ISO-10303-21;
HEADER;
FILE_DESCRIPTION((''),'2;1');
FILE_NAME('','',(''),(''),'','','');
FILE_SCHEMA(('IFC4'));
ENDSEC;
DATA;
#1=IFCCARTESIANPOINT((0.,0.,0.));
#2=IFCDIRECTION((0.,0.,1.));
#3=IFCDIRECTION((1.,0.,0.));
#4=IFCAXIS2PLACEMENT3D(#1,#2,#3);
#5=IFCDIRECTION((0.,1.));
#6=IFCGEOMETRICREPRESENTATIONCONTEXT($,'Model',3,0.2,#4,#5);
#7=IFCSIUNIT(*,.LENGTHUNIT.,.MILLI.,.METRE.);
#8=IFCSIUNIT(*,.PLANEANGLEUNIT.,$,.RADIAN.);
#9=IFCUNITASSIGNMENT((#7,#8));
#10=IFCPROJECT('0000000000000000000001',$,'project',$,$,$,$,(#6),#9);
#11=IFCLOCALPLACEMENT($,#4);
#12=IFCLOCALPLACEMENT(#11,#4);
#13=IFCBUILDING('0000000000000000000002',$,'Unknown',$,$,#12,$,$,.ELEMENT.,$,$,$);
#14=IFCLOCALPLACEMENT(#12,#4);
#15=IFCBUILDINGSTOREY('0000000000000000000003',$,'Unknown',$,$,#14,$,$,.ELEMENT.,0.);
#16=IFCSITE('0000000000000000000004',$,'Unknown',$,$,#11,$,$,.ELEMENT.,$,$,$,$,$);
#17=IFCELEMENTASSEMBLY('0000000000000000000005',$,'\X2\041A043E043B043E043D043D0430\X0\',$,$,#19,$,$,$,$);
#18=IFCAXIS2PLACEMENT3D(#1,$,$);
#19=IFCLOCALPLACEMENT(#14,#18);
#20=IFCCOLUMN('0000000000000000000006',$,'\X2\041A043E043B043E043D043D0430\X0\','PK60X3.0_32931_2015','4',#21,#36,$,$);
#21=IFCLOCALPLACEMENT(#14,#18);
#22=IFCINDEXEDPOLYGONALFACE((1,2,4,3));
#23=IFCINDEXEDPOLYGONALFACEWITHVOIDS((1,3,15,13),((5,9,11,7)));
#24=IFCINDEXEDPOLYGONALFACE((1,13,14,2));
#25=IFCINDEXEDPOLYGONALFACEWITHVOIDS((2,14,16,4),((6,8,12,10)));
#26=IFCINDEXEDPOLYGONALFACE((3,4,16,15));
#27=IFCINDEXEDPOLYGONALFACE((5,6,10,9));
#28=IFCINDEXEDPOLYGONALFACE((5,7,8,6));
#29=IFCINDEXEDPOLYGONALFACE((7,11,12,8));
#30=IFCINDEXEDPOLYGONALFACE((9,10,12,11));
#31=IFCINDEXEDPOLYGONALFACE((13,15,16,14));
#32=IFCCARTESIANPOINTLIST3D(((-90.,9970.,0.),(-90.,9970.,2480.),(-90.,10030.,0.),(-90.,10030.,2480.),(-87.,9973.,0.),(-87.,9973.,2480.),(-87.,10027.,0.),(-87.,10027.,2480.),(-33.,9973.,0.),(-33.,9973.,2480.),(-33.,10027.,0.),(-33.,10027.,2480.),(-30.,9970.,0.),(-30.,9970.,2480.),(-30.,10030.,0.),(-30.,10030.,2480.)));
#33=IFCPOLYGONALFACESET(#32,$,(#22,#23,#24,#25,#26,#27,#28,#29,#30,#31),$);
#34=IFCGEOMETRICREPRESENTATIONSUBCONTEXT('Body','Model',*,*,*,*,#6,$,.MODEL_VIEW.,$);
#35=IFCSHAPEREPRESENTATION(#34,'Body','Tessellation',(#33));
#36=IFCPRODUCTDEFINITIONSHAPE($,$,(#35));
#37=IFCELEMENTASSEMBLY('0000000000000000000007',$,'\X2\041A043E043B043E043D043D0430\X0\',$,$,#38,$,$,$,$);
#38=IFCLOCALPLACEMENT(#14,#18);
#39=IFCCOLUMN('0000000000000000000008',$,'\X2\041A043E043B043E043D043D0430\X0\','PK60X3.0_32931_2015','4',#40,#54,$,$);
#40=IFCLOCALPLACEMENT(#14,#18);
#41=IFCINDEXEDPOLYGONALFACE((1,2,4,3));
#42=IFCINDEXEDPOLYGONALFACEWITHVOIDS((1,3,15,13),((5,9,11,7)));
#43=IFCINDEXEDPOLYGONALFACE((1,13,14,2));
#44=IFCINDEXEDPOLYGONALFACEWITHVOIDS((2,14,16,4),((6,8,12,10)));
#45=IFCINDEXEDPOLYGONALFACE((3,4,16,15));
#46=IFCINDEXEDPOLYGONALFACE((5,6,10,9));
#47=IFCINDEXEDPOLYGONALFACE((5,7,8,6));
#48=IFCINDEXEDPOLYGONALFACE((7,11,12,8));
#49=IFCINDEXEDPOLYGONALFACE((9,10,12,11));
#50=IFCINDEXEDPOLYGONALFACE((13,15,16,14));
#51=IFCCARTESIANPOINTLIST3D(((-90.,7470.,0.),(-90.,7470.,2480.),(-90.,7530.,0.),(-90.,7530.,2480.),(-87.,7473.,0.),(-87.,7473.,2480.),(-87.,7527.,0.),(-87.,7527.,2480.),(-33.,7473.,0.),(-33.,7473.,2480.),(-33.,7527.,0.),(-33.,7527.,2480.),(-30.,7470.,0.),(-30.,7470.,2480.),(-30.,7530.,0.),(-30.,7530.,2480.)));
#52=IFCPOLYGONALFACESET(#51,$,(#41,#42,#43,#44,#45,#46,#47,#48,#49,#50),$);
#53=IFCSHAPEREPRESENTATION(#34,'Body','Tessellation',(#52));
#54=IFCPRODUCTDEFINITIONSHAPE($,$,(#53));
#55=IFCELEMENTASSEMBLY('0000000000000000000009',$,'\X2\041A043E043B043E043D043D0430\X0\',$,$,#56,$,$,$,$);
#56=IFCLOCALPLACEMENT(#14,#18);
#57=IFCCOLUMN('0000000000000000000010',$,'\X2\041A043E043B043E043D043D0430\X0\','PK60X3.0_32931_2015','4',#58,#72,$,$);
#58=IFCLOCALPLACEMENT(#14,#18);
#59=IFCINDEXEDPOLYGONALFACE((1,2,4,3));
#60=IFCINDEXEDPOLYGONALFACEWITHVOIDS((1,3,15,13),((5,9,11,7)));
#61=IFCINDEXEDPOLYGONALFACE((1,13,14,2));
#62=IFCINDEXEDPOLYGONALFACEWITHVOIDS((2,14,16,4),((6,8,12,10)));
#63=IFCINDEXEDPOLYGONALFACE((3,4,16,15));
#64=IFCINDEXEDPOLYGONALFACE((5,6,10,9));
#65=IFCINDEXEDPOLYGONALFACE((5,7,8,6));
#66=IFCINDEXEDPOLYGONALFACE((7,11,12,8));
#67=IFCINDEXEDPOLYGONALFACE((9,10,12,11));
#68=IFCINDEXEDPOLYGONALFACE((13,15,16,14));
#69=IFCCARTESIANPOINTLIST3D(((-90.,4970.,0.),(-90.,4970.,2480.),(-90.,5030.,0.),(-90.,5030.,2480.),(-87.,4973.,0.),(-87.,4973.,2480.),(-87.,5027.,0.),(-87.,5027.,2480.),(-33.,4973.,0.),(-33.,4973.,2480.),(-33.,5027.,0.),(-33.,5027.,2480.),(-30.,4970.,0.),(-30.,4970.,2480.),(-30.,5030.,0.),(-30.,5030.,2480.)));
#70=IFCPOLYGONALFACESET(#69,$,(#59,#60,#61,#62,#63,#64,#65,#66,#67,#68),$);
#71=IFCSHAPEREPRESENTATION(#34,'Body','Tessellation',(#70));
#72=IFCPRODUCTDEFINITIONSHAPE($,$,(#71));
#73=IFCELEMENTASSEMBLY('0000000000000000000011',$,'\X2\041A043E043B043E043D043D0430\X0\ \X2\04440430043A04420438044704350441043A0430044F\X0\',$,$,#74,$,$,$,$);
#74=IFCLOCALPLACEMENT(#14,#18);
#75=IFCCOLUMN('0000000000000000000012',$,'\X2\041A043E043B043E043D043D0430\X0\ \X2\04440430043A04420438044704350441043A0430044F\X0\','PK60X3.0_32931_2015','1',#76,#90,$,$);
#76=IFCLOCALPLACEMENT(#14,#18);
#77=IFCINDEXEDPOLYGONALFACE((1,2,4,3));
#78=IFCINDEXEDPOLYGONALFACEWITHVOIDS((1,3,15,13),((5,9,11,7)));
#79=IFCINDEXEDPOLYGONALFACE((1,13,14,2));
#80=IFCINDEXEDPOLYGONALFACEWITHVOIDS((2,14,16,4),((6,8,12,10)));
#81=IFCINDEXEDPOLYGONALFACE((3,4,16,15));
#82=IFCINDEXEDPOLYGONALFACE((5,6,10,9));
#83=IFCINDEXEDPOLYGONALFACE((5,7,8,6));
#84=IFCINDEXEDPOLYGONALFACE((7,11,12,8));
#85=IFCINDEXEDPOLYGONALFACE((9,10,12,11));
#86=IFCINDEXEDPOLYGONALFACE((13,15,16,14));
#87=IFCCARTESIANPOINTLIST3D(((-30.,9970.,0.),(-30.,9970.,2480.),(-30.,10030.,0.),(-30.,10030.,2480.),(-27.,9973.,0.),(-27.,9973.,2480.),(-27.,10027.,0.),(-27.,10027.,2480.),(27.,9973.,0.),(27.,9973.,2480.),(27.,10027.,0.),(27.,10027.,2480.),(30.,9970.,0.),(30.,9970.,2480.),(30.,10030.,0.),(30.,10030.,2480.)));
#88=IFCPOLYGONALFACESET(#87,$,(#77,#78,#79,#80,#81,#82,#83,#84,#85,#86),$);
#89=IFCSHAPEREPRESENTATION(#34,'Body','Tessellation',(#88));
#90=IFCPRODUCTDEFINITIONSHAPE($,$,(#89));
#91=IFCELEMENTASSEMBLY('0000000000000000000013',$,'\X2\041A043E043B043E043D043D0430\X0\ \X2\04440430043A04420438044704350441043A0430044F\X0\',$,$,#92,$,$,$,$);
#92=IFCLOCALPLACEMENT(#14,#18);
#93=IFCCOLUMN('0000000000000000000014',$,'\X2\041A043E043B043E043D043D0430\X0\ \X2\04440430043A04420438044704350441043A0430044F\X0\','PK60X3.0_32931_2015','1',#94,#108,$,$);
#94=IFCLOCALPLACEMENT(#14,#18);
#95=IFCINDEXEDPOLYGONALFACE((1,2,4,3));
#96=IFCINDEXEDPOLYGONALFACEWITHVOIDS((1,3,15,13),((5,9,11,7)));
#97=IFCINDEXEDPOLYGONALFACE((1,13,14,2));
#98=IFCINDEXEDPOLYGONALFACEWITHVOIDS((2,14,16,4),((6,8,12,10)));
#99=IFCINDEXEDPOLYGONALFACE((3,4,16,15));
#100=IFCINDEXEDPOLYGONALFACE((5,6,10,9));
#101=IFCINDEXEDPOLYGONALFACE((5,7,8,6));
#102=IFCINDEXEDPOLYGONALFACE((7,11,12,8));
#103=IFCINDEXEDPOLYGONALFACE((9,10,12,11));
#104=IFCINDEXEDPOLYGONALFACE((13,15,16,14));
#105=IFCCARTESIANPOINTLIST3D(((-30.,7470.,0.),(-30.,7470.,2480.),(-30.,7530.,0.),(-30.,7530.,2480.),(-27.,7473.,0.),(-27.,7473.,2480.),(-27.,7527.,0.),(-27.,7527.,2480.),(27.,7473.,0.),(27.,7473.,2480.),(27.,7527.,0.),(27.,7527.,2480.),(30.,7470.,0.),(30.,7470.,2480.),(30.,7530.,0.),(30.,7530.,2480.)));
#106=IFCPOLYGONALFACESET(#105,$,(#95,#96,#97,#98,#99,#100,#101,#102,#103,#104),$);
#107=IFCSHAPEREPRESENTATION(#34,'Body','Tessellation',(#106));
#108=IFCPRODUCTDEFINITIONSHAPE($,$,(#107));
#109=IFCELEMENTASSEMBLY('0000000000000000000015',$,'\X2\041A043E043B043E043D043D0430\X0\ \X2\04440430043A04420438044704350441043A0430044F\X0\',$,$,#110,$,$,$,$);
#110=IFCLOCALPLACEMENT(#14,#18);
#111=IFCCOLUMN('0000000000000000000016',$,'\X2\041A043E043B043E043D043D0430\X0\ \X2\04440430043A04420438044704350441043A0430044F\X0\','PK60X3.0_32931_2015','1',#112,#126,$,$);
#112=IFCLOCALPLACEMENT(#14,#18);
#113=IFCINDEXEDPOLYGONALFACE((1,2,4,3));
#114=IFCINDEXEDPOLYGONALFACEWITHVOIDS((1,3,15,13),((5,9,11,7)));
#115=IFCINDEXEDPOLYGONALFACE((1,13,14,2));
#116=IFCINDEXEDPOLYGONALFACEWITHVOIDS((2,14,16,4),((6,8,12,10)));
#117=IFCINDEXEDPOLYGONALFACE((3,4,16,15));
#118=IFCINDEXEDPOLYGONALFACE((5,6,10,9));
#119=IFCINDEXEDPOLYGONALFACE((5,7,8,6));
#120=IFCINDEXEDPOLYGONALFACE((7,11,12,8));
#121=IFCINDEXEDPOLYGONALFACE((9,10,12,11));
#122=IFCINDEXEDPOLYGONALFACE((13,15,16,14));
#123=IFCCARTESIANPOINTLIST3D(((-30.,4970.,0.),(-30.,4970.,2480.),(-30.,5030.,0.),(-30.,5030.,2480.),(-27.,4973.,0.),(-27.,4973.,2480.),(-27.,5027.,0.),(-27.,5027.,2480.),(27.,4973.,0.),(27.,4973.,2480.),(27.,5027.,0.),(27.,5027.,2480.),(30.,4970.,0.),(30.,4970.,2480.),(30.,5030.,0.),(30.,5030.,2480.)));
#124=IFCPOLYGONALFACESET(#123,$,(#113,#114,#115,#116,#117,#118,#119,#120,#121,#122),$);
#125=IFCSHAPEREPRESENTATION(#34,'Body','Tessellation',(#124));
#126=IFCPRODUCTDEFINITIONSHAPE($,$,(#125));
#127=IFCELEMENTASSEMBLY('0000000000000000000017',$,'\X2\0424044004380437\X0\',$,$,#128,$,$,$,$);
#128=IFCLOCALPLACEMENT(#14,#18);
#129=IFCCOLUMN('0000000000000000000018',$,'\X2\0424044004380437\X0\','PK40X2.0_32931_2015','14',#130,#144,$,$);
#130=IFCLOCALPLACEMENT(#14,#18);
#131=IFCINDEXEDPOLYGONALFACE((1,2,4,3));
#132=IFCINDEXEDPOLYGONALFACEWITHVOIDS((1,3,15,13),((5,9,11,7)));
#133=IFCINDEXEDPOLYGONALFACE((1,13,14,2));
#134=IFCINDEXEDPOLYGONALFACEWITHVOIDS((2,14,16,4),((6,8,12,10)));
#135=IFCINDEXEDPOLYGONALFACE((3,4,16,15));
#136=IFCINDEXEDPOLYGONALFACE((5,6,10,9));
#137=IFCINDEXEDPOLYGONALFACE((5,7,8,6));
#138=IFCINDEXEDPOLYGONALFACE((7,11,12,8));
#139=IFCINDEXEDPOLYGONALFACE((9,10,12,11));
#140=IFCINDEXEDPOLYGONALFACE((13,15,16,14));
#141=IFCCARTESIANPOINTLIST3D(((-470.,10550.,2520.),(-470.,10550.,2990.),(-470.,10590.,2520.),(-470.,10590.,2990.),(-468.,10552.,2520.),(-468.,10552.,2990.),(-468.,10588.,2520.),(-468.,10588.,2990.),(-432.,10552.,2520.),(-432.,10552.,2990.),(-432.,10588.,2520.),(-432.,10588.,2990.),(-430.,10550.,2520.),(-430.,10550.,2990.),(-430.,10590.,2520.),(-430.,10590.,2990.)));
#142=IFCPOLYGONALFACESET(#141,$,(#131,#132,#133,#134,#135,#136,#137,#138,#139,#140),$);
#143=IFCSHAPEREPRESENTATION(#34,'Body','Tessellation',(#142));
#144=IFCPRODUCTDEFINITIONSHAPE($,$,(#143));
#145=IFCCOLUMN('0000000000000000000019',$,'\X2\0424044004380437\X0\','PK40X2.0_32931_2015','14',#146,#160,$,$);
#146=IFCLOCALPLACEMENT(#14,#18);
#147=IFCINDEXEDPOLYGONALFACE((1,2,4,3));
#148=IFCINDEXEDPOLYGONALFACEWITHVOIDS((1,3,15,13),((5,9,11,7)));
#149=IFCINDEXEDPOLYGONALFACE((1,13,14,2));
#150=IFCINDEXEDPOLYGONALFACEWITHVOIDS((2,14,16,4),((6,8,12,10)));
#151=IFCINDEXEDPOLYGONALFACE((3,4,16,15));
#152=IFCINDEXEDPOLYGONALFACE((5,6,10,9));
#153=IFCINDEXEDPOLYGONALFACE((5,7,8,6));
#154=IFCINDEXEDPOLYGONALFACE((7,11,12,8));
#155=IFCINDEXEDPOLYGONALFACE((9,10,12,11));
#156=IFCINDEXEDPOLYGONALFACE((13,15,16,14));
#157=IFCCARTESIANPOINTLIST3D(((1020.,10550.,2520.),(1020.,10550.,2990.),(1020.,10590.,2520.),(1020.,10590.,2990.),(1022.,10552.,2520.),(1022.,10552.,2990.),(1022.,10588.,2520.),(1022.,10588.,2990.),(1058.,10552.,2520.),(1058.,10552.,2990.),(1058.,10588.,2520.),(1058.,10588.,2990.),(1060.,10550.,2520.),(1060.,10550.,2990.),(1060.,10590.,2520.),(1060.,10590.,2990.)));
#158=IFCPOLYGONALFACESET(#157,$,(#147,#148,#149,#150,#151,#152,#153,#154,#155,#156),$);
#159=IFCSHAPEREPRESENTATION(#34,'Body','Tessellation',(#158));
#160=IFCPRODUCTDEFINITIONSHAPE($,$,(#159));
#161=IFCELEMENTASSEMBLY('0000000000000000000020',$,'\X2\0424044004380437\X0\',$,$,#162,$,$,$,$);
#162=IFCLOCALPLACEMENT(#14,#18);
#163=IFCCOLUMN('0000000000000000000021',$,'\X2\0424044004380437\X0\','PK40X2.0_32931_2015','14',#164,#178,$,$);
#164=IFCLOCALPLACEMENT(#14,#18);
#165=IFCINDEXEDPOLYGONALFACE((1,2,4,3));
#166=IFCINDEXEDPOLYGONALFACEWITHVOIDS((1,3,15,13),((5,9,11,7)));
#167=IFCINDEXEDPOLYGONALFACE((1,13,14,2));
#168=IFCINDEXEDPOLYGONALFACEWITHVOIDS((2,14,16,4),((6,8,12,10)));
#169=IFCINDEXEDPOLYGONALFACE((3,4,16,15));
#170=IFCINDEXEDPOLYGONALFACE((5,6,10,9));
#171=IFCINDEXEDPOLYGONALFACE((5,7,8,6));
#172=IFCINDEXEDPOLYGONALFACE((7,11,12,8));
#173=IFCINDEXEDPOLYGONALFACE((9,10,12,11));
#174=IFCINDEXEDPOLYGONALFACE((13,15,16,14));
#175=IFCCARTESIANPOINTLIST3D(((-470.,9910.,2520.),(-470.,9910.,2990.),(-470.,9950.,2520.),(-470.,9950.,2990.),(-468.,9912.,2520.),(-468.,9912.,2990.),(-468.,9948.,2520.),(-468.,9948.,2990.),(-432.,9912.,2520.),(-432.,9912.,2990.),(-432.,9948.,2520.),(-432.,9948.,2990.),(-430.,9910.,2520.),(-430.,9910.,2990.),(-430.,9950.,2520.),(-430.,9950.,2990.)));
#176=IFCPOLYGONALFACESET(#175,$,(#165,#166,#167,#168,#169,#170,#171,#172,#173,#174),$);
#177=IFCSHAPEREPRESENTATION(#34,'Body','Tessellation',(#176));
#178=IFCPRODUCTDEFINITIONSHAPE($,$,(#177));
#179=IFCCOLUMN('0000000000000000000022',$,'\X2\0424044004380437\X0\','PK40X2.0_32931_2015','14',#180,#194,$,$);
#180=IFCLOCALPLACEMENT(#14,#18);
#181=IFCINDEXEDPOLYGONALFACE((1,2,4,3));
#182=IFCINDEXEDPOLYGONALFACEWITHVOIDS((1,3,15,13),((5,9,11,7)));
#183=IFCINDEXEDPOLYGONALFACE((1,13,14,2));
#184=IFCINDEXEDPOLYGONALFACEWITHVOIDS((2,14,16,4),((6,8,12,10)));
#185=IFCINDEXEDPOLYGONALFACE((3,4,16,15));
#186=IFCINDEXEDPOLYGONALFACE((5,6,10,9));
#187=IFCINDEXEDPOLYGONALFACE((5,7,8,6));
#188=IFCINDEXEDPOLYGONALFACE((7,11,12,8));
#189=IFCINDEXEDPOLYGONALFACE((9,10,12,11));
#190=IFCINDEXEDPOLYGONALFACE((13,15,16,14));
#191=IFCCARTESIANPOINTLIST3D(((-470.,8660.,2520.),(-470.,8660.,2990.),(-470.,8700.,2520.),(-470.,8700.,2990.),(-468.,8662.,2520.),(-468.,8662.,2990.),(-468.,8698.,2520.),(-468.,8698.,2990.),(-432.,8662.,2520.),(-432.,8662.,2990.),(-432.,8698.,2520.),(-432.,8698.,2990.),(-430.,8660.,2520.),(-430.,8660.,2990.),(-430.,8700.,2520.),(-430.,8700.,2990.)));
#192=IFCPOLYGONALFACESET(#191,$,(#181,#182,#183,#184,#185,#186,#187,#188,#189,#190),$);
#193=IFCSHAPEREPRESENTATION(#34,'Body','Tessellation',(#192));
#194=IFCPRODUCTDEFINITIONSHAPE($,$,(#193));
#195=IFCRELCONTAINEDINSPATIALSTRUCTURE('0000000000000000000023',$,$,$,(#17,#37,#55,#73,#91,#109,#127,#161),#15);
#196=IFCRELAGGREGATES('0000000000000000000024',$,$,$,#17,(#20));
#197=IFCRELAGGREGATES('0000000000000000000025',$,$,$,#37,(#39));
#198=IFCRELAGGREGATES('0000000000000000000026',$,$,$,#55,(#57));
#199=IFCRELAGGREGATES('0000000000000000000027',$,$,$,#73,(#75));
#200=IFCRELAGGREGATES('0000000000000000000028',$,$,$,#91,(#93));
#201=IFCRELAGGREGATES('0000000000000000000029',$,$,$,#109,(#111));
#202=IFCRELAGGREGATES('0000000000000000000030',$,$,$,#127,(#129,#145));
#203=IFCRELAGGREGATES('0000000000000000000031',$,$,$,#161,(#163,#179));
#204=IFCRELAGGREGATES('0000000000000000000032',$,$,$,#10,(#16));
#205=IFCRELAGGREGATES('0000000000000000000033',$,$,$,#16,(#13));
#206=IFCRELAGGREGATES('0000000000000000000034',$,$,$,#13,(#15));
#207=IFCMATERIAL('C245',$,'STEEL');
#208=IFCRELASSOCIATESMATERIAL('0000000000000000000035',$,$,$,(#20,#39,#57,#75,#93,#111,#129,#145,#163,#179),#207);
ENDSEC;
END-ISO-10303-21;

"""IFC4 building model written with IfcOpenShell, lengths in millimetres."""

from ifc_helpers import new_model, si_unit, direction, frame, origin_with_axes, place, context, subcontext, project, spatial, line, indexed_curve, outline, extrude, material, element, aggregate, save


model = new_model("IFC4")

# Units and contexts
model_context = context("Model", 3, precision=0.2, world=origin_with_axes(), true_north=direction((0.0, 1.0)))
body_context = subcontext(model_context, "Body", "Model", "MODEL_VIEW")
ifc_project = project(units=[si_unit("LENGTHUNIT", "METRE", prefix="MILLI"), si_unit("PLANEANGLEUNIT", "RADIAN")], contexts=[model_context])

# Site, building, storey
site_placement = place(None, origin_with_axes())
site = spatial("IfcSite", under=ifc_project, at=site_placement, Name="Unknown", CompositionType="ELEMENT")
building_placement = place(site_placement, origin_with_axes())
building = spatial("IfcBuilding", under=site, at=building_placement, Name="Unknown", CompositionType="ELEMENT")
storey_placement = place(building_placement, origin_with_axes())
storey = spatial("IfcBuildingStorey", under=building, at=storey_placement, Name="Unknown", CompositionType="ELEMENT", Elevation=0.0)

# Element assemblies, columns
assembly_1_placement = place(storey_placement, frame((-60.0, 10000.0, 0.0), z_axis=(-1.0, 0.0, 0.0), x_axis=(0.0, 0.0, 1.0)))
assembly_1 = element("IfcElementAssembly", 1, at=assembly_1_placement, inside=storey, Name="Колонна")
ifc_material = material(Name="C245", Category="STEEL")
column_1_placement = place(assembly_1_placement, origin_with_axes())
column_1 = element("IfcColumn", 2, at=column_1_placement, material=ifc_material, Name="Колонна", Description="PK60X3.0_32931_2015", ObjectType="4", context=body_context, shape_type="SolidModel", body=[
    extrude(outline(indexed_curve([(-30.0, -30.0), (30.0, -30.0), (30.0, 30.0), (-30.0, 30.0)], segments=[line(1, 2, 3, 4, 1)]), holes=[indexed_curve([(-27.0, -27.0), (-27.0, 27.0), (27.0, 27.0), (27.0, -27.0)], segments=[line(1, 2, 3, 4, 1)])]), frame((0.0, 0.0, 0.0), z_axis=(-1.0, 0.0, 0.0), x_axis=(0.0, 0.0, 1.0)), (0.0, 0.0, -1.0), 2480.0),
])
aggregate(assembly_1, [column_1])
assembly_2_placement = place(storey_placement, frame((-60.0, 7500.0, 0.0), z_axis=(-1.0, 0.0, 0.0), x_axis=(0.0, 0.0, 1.0)))
assembly_2 = element("IfcElementAssembly", 3, at=assembly_2_placement, inside=storey, Name="Колонна")
column_2_placement = place(assembly_2_placement, origin_with_axes())
column_2 = element("IfcColumn", 4, at=column_2_placement, material=ifc_material, Name="Колонна", Description="PK60X3.0_32931_2015", ObjectType="4", context=body_context, shape_type="SolidModel", body=[
    extrude(outline(indexed_curve([(-30.0, -30.0), (30.0, -30.0), (30.0, 30.0), (-30.0, 30.0)], segments=[line(1, 2, 3, 4, 1)]), holes=[indexed_curve([(-27.0, -27.0), (-27.0, 27.0), (27.0, 27.0), (27.0, -27.0)], segments=[line(1, 2, 3, 4, 1)])]), frame((0.0, 0.0, 0.0), z_axis=(-1.0, 0.0, 0.0), x_axis=(0.0, 0.0, 1.0)), (0.0, 0.0, -1.0), 2480.0),
])
aggregate(assembly_2, [column_2])
assembly_3_placement = place(storey_placement, frame((-60.0, 5000.0, 0.0), z_axis=(-1.0, 0.0, 0.0), x_axis=(0.0, 0.0, 1.0)))
assembly_3 = element("IfcElementAssembly", 5, at=assembly_3_placement, inside=storey, Name="Колонна")
column_3_placement = place(assembly_3_placement, origin_with_axes())
column_3 = element("IfcColumn", 6, at=column_3_placement, material=ifc_material, Name="Колонна", Description="PK60X3.0_32931_2015", ObjectType="4", context=body_context, shape_type="SolidModel", body=[
    extrude(outline(indexed_curve([(-30.0, -30.0), (30.0, -30.0), (30.0, 30.0), (-30.0, 30.0)], segments=[line(1, 2, 3, 4, 1)]), holes=[indexed_curve([(-27.0, -27.0), (-27.0, 27.0), (27.0, 27.0), (27.0, -27.0)], segments=[line(1, 2, 3, 4, 1)])]), frame((0.0, 0.0, 0.0), z_axis=(-1.0, 0.0, 0.0), x_axis=(0.0, 0.0, 1.0)), (0.0, 0.0, -1.0), 2480.0),
])
aggregate(assembly_3, [column_3])
assembly_4_placement = place(storey_placement, frame((0.0, 10000.0, 0.0), z_axis=(-1.0, 0.0, 0.0), x_axis=(0.0, 0.0, 1.0)))
assembly_4 = element("IfcElementAssembly", 7, at=assembly_4_placement, inside=storey, Name="Колонна фактическая")
column_4_placement = place(assembly_4_placement, origin_with_axes())
column_4 = element("IfcColumn", 8, at=column_4_placement, material=ifc_material, Name="Колонна фактическая", Description="PK60X3.0_32931_2015", ObjectType="1", context=body_context, shape_type="SolidModel", body=[
    extrude(outline(indexed_curve([(-30.0, -30.0), (30.0, -30.0), (30.0, 30.0), (-30.0, 30.0)], segments=[line(1, 2, 3, 4, 1)]), holes=[indexed_curve([(-27.0, -27.0), (-27.0, 27.0), (27.0, 27.0), (27.0, -27.0)], segments=[line(1, 2, 3, 4, 1)])]), frame((0.0, 0.0, 0.0), z_axis=(-1.0, 0.0, 0.0), x_axis=(0.0, 0.0, 1.0)), (0.0, 0.0, -1.0), 2480.0),
])
aggregate(assembly_4, [column_4])
assembly_5_placement = place(storey_placement, frame((0.0, 7500.0, 0.0), z_axis=(-1.0, 0.0, 0.0), x_axis=(0.0, 0.0, 1.0)))
assembly_5 = element("IfcElementAssembly", 9, at=assembly_5_placement, inside=storey, Name="Колонна фактическая")
column_5_placement = place(assembly_5_placement, origin_with_axes())
column_5 = element("IfcColumn", 10, at=column_5_placement, material=ifc_material, Name="Колонна фактическая", Description="PK60X3.0_32931_2015", ObjectType="1", context=body_context, shape_type="SolidModel", body=[
    extrude(outline(indexed_curve([(-30.0, -30.0), (30.0, -30.0), (30.0, 30.0), (-30.0, 30.0)], segments=[line(1, 2, 3, 4, 1)]), holes=[indexed_curve([(-27.0, -27.0), (-27.0, 27.0), (27.0, 27.0), (27.0, -27.0)], segments=[line(1, 2, 3, 4, 1)])]), frame((0.0, 0.0, 0.0), z_axis=(-1.0, 0.0, 0.0), x_axis=(0.0, 0.0, 1.0)), (0.0, 0.0, -1.0), 2480.0),
])
aggregate(assembly_5, [column_5])
assembly_6_placement = place(storey_placement, frame((0.0, 5000.0, 0.0), z_axis=(-1.0, 0.0, 0.0), x_axis=(0.0, 0.0, 1.0)))
assembly_6 = element("IfcElementAssembly", 11, at=assembly_6_placement, inside=storey, Name="Колонна фактическая")
column_6_placement = place(assembly_6_placement, origin_with_axes())
column_6 = element("IfcColumn", 12, at=column_6_placement, material=ifc_material, Name="Колонна фактическая", Description="PK60X3.0_32931_2015", ObjectType="1", context=body_context, shape_type="SolidModel", body=[
    extrude(outline(indexed_curve([(-30.0, -30.0), (30.0, -30.0), (30.0, 30.0), (-30.0, 30.0)], segments=[line(1, 2, 3, 4, 1)]), holes=[indexed_curve([(-27.0, -27.0), (-27.0, 27.0), (27.0, 27.0), (27.0, -27.0)], segments=[line(1, 2, 3, 4, 1)])]), frame((0.0, 0.0, 0.0), z_axis=(-1.0, 0.0, 0.0), x_axis=(0.0, 0.0, 1.0)), (0.0, 0.0, -1.0), 2480.0),
])
aggregate(assembly_6, [column_6])

# Element assemblies, columns
assembly_7_placement = place(storey_placement, frame((-470.0, 10570.0, 3010.0), z_axis=(0.0, -1.0, 0.0), x_axis=(1.0, 0.0, 0.0)))
assembly_7 = element("IfcElementAssembly", 13, at=assembly_7_placement, inside=storey, Name="Фриз")
column_7_placement = place(assembly_7_placement, frame((20.0, -490.0, 0.0), z_axis=(0.0, 0.0, -1.0), x_axis=(0.0, 1.0, 0.0)))
column_7 = element("IfcColumn", 14, at=column_7_placement, material=ifc_material, Name="Фриз", Description="PK40X2.0_32931_2015", ObjectType="14", context=body_context, shape_type="SolidModel", body=[
    extrude(outline(indexed_curve([(-20.0, -20.0), (20.0, -20.0), (20.0, 20.0), (-20.0, 20.0)], segments=[line(1, 2, 3, 4, 1)]), holes=[indexed_curve([(-18.0, -18.0), (-18.0, 18.0), (18.0, 18.0), (18.0, -18.0)], segments=[line(1, 2, 3, 4, 1)])]), frame((0.0, 0.0, 0.0), z_axis=(-1.0, 0.0, 0.0), x_axis=(0.0, 0.0, 1.0)), (0.0, 0.0, -1.0), 470.0),
])
column_8_placement = place(assembly_7_placement, frame((1510.0, -490.0, 0.0), z_axis=(0.0, 0.0, -1.0), x_axis=(0.0, 1.0, 0.0)))
column_8 = element("IfcColumn", 15, at=column_8_placement, material=ifc_material, Name="Фриз", Description="PK40X2.0_32931_2015", ObjectType="14", context=body_context, shape_type="SolidModel", body=[
    extrude(outline(indexed_curve([(-20.0, -20.0), (20.0, -20.0), (20.0, 20.0), (-20.0, 20.0)], segments=[line(1, 2, 3, 4, 1)]), holes=[indexed_curve([(-18.0, -18.0), (-18.0, 18.0), (18.0, 18.0), (18.0, -18.0)], segments=[line(1, 2, 3, 4, 1)])]), frame((0.0, 0.0, 0.0), z_axis=(-1.0, 0.0, 0.0), x_axis=(0.0, 0.0, 1.0)), (0.0, 0.0, -1.0), 470.0),
])
assembly_8_placement = place(storey_placement, frame((-450.0, -500.0, 3010.0), z_axis=(1.0, 0.0, 0.0), x_axis=(0.0, 1.0, 0.0)))
assembly_8 = element("IfcElementAssembly", 16, at=assembly_8_placement, inside=storey, Name="Фриз")
column_9_placement = place(assembly_8_placement, frame((10430.0, -490.0, 0.0), z_axis=(1.0, 0.0, 0.0), x_axis=(0.0, 1.0, 0.0)))
column_9 = element("IfcColumn", 17, at=column_9_placement, material=ifc_material, Name="Фриз", Description="PK40X2.0_32931_2015", ObjectType="14", context=body_context, shape_type="SolidModel", body=[
    extrude(outline(indexed_curve([(-20.0, -20.0), (20.0, -20.0), (20.0, 20.0), (-20.0, 20.0)], segments=[line(1, 2, 3, 4, 1)]), holes=[indexed_curve([(-18.0, -18.0), (-18.0, 18.0), (18.0, 18.0), (18.0, -18.0)], segments=[line(1, 2, 3, 4, 1)])]), frame((0.0, 0.0, 0.0), z_axis=(-1.0, 0.0, 0.0), x_axis=(0.0, 0.0, 1.0)), (0.0, 0.0, -1.0), 470.0),
])
column_10_placement = place(assembly_8_placement, frame((9180.0, -490.0, 0.0), z_axis=(1.0, 0.0, 0.0), x_axis=(0.0, 1.0, 0.0)))
column_10 = element("IfcColumn", 18, at=column_10_placement, material=ifc_material, Name="Фриз", Description="PK40X2.0_32931_2015", ObjectType="14", context=body_context, shape_type="SolidModel", body=[
    extrude(outline(indexed_curve([(-20.0, -20.0), (20.0, -20.0), (20.0, 20.0), (-20.0, 20.0)], segments=[line(1, 2, 3, 4, 1)]), holes=[indexed_curve([(-18.0, -18.0), (-18.0, 18.0), (18.0, 18.0), (18.0, -18.0)], segments=[line(1, 2, 3, 4, 1)])]), frame((0.0, 0.0, 0.0), z_axis=(-1.0, 0.0, 0.0), x_axis=(0.0, 0.0, 1.0)), (0.0, 0.0, -1.0), 470.0),
])

aggregate(assembly_7, [column_7, column_8])
aggregate(assembly_8, [column_9, column_10])

save(model, "model.ifc")
